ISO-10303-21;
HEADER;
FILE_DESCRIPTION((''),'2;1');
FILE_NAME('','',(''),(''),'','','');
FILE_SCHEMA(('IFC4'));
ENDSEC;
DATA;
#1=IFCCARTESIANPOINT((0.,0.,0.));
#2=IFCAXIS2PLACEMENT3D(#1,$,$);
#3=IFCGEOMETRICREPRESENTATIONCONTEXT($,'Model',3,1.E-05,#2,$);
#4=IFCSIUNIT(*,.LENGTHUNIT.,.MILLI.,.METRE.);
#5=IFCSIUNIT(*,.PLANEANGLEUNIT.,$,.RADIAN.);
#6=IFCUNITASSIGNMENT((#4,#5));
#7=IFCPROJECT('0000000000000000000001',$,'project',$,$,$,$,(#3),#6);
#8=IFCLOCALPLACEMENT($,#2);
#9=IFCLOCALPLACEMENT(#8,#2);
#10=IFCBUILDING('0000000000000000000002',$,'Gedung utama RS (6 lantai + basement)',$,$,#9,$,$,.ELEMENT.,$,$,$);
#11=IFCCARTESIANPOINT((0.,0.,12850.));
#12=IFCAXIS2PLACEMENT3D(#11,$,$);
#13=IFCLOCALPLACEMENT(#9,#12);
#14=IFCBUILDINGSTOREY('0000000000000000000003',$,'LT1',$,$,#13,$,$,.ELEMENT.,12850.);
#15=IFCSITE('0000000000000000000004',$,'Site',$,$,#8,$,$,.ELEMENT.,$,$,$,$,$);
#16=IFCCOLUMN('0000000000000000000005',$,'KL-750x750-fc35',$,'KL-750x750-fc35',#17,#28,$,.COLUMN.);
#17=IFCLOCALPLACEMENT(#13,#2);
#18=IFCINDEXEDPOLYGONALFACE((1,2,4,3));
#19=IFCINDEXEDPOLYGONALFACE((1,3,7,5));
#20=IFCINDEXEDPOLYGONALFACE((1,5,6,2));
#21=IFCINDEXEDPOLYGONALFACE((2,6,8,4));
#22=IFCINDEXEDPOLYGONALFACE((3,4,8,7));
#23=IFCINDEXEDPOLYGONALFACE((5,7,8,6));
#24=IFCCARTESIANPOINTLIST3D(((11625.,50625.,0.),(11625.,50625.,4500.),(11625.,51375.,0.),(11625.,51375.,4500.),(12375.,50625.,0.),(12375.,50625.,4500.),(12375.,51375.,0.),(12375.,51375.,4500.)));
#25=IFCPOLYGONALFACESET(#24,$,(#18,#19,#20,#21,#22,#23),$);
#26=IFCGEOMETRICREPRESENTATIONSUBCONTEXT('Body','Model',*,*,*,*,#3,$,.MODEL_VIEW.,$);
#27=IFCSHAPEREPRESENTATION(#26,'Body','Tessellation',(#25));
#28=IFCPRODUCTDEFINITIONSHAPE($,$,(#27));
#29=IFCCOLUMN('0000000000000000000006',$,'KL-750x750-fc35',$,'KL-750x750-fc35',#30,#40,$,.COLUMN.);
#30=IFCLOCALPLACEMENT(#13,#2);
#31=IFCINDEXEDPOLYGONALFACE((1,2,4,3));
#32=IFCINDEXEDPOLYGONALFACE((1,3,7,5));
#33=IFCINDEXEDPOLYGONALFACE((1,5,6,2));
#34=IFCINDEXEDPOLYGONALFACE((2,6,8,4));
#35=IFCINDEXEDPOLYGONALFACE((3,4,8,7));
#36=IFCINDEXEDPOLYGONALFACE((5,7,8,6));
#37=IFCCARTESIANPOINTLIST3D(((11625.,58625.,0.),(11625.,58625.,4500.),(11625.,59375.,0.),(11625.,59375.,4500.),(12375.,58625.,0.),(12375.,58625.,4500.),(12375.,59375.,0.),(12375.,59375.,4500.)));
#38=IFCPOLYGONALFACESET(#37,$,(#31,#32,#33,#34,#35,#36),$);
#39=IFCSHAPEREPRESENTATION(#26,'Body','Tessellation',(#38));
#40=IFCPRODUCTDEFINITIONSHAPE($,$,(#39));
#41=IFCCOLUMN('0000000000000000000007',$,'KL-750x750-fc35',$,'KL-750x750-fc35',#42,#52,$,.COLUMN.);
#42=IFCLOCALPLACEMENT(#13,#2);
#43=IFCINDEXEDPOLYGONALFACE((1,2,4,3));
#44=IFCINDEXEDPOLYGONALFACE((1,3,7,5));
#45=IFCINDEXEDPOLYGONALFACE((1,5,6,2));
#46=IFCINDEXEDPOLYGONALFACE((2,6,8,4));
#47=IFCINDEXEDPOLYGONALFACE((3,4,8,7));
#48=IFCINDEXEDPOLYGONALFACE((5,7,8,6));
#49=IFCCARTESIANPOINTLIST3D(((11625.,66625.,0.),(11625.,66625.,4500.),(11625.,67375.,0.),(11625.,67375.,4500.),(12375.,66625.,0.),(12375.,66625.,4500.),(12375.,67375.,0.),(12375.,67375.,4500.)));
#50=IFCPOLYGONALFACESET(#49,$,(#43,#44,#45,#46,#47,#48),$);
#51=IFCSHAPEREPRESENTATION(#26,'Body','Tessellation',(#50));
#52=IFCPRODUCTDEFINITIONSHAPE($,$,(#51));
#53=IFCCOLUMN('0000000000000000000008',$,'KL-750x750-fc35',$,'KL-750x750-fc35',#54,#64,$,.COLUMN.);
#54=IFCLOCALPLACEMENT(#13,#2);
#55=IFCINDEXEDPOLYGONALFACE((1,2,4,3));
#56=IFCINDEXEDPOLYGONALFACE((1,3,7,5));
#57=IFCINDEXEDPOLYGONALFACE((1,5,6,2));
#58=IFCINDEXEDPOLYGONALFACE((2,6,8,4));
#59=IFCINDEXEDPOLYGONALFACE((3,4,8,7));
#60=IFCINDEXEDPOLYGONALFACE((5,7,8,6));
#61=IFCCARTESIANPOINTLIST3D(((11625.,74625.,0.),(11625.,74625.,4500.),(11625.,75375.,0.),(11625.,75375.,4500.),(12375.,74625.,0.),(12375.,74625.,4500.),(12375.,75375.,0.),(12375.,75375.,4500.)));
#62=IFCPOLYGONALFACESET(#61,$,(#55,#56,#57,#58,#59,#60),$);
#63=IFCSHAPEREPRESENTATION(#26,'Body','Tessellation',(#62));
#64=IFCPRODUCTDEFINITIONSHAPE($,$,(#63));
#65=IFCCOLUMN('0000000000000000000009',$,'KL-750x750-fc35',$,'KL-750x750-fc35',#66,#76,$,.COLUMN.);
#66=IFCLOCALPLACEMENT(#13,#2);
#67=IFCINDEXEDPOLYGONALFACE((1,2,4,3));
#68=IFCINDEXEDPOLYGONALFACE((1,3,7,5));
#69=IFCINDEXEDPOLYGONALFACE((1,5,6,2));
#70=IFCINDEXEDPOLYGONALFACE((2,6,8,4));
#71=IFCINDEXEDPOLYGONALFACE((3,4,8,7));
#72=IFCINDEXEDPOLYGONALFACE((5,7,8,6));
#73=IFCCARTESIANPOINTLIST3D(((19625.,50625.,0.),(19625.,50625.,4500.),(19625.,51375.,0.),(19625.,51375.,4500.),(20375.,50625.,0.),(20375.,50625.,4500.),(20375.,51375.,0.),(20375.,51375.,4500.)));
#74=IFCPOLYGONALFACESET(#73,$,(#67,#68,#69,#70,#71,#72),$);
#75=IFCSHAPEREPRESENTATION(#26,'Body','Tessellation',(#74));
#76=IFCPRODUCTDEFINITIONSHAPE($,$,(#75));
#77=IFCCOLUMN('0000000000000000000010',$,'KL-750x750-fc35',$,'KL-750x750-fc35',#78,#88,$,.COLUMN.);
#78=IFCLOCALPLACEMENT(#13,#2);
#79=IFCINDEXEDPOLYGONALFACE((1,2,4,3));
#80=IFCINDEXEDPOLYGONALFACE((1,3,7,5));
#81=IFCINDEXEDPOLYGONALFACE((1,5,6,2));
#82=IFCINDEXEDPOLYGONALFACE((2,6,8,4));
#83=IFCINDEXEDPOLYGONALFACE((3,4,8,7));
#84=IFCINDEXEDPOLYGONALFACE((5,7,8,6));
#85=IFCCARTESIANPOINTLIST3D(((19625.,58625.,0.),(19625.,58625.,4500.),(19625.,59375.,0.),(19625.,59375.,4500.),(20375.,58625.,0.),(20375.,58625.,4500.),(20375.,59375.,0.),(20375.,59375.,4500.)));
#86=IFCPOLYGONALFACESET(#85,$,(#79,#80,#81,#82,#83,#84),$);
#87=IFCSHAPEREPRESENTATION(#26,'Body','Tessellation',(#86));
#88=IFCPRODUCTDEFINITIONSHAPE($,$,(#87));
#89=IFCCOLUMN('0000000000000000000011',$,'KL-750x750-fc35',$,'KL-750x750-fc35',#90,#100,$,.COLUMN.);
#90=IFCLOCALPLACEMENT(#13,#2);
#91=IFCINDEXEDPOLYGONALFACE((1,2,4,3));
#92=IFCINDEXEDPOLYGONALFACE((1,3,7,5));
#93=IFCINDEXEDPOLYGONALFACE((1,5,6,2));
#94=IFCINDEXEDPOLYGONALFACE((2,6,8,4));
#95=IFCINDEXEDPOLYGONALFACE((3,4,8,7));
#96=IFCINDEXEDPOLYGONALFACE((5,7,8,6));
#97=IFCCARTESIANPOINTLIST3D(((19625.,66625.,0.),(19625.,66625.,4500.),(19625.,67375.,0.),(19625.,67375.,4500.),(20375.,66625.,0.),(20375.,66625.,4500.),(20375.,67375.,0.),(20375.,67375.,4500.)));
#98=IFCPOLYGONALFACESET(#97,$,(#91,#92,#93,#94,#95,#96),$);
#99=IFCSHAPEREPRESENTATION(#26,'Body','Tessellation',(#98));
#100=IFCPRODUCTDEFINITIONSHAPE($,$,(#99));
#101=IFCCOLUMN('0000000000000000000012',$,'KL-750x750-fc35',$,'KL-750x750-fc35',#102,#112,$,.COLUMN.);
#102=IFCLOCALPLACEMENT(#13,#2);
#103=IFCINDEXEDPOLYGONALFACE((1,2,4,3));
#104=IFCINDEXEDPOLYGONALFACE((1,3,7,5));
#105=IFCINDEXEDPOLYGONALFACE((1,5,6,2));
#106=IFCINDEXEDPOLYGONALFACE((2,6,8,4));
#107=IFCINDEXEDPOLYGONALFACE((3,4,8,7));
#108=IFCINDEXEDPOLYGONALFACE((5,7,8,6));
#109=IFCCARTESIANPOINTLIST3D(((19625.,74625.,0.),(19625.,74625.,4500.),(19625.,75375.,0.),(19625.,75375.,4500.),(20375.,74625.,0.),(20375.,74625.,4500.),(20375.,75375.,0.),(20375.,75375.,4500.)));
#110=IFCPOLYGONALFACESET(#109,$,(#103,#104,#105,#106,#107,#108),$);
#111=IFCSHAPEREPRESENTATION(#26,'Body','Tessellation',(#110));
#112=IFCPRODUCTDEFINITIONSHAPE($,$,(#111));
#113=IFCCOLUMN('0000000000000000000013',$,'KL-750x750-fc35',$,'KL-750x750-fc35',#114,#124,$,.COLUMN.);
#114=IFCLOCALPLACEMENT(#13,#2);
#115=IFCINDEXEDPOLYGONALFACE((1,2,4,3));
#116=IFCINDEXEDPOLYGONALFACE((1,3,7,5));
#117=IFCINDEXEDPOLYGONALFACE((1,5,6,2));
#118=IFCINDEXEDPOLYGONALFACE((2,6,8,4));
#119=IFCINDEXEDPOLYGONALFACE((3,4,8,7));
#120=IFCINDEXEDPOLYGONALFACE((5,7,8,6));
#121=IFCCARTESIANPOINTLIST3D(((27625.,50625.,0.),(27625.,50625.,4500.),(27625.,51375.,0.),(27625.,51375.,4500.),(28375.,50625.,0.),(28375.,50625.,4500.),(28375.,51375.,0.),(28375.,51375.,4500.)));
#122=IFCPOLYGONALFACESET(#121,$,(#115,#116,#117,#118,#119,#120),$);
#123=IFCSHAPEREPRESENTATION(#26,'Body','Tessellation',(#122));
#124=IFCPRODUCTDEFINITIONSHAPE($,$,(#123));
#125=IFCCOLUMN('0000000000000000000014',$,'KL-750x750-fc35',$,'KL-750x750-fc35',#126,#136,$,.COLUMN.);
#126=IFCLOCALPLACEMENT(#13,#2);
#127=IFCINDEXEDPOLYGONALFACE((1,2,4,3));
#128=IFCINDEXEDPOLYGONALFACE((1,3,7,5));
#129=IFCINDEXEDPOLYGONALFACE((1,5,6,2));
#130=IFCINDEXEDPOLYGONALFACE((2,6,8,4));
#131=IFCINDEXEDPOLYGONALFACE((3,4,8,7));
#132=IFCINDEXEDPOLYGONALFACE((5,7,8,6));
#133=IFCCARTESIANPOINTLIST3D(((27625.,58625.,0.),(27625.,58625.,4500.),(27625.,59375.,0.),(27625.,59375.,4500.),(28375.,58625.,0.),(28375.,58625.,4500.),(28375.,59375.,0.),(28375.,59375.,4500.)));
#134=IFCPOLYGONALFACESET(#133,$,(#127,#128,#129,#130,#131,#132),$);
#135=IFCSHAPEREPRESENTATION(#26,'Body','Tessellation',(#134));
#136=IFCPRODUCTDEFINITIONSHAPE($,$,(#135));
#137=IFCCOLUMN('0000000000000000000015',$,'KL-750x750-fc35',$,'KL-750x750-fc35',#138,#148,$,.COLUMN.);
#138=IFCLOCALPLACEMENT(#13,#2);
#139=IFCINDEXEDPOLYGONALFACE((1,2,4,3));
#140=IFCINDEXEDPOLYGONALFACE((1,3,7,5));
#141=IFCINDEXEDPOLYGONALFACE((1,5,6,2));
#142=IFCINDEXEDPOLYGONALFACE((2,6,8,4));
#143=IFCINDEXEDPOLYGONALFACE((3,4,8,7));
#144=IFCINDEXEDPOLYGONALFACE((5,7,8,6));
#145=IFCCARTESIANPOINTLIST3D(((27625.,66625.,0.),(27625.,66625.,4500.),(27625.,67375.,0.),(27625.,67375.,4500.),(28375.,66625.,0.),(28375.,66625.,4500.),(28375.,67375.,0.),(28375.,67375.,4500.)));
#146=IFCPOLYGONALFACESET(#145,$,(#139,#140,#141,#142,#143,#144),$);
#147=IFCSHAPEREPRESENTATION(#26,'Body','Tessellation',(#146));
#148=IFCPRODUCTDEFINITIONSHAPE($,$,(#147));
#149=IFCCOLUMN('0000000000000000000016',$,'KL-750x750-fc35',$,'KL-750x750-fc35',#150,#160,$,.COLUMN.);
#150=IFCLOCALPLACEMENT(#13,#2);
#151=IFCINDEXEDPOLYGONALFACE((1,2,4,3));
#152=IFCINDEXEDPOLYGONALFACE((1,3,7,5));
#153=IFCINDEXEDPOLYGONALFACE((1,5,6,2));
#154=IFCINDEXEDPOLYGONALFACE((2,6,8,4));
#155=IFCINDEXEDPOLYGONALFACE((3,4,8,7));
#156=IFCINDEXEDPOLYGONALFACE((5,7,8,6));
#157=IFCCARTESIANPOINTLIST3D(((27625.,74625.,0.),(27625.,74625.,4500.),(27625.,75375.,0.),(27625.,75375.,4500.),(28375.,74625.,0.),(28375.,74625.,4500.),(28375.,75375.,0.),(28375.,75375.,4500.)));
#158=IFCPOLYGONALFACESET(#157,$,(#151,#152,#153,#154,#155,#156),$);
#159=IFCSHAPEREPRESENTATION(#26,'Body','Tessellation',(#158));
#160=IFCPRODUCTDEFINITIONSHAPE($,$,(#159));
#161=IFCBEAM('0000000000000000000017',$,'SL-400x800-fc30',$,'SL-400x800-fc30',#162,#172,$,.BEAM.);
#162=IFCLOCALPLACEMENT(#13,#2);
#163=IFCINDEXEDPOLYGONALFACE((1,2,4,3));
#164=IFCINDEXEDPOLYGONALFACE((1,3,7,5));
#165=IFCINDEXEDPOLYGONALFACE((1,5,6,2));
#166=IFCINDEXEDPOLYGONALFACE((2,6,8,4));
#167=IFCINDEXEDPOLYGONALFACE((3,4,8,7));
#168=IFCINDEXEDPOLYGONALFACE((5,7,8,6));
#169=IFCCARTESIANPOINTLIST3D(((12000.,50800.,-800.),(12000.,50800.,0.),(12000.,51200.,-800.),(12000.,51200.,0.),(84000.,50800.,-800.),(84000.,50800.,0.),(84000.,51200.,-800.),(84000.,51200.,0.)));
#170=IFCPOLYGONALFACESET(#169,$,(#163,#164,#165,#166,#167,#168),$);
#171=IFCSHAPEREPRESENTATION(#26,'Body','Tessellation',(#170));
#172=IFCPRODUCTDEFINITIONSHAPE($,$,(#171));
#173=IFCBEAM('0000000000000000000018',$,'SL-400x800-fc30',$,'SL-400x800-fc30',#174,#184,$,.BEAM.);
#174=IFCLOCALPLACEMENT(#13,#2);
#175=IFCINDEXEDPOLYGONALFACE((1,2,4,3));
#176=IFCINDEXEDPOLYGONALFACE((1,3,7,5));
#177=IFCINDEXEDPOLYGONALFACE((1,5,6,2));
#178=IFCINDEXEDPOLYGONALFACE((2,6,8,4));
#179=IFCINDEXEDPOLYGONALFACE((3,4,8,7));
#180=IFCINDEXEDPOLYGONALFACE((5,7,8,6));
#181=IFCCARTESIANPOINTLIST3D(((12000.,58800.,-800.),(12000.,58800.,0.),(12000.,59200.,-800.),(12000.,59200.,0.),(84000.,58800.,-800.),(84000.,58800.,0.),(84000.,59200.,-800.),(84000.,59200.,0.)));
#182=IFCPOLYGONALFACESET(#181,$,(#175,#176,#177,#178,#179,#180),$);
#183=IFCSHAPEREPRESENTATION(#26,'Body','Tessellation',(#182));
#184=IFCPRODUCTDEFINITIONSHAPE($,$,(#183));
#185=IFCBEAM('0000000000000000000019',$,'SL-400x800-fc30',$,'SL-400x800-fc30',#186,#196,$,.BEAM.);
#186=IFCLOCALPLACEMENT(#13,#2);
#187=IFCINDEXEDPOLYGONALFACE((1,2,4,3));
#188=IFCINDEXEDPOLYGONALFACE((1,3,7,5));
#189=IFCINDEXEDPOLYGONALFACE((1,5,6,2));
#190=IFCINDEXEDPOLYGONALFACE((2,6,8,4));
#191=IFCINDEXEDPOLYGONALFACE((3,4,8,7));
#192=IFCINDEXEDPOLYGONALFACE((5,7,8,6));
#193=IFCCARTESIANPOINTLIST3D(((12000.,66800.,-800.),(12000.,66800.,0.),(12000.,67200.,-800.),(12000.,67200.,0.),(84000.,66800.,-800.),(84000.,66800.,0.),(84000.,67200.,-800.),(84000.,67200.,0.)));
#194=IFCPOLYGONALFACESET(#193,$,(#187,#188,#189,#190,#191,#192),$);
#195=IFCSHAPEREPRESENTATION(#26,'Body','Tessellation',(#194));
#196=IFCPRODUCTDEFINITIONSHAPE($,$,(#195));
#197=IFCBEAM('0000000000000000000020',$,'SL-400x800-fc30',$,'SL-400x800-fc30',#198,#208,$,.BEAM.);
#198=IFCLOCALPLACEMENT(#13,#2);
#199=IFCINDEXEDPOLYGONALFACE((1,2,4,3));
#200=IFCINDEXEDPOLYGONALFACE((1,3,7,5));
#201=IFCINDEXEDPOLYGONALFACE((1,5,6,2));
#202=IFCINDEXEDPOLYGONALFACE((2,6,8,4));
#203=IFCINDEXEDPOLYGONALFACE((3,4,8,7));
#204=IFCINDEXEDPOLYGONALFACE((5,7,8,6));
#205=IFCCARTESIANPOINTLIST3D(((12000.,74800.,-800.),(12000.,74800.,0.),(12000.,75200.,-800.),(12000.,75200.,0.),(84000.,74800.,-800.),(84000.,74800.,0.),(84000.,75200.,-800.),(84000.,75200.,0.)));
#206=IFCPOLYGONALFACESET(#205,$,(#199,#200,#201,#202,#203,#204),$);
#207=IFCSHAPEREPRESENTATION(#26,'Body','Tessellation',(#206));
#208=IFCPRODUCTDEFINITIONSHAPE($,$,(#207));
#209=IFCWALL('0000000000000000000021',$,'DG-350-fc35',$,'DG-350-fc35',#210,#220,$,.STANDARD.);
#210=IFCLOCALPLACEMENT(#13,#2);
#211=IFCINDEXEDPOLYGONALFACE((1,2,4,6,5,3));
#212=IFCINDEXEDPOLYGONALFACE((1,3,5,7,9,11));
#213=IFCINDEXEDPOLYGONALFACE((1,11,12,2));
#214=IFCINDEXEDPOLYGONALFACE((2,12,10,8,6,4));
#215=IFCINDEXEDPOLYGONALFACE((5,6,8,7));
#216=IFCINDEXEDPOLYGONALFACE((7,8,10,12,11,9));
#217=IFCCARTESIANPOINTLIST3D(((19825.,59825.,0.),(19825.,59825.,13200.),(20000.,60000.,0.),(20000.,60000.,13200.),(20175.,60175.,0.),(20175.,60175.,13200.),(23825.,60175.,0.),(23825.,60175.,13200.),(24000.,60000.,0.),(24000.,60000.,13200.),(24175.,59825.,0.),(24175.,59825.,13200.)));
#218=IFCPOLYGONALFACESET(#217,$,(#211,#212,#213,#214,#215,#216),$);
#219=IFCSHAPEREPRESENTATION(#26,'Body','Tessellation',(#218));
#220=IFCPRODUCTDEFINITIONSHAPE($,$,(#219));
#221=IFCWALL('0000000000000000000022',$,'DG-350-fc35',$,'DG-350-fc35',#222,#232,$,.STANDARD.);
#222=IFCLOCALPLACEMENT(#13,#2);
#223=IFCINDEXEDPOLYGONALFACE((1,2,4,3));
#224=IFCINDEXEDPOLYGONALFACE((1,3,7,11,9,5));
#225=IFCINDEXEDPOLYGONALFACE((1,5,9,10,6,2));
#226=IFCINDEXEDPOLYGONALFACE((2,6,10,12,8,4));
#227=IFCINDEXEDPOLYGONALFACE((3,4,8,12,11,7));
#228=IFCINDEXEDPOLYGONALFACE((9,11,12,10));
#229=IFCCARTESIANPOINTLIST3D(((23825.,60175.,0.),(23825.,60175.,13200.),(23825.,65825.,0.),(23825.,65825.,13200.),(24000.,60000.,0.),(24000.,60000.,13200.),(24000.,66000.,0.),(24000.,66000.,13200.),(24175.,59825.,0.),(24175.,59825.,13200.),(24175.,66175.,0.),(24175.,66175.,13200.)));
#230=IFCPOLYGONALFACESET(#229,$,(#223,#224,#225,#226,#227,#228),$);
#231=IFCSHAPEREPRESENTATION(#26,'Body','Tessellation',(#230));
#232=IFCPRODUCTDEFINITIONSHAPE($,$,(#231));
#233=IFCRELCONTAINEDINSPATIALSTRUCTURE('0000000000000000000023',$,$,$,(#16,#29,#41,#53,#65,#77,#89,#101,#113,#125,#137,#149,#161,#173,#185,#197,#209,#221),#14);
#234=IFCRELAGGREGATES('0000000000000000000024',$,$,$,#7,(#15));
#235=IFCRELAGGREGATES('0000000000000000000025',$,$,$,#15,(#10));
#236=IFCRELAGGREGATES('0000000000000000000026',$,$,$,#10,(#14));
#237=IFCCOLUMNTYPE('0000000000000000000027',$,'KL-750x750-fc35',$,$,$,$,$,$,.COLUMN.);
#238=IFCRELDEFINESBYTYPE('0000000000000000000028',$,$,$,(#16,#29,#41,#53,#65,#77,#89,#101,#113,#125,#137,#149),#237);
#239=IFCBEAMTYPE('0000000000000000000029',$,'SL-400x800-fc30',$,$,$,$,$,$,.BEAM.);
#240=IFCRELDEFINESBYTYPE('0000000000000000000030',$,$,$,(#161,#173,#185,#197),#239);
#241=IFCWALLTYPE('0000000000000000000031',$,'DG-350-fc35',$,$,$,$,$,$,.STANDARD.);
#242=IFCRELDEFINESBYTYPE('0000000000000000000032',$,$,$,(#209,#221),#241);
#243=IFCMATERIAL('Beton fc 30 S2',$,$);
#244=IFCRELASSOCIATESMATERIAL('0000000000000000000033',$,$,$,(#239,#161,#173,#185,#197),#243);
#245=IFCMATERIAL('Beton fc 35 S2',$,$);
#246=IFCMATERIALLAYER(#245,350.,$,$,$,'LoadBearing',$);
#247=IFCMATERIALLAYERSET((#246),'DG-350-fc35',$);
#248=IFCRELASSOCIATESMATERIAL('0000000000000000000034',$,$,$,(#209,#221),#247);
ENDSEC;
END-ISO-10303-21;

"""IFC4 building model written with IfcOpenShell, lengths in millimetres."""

from ifc_helpers import new_model, si_unit, frame, origin, origin_2d, place, context, subcontext, project, spatial, polyline, rectangle, outline, extrude, material, layer, layer_set, layer_usage, material_profile, profile_set, profile_usage, type_object, element, save


model = new_model("IFC4")

# Units and contexts
model_context = context("Model", 3, precision=1e-05, world=origin())
body_context = subcontext(model_context, "Body", "Model", "MODEL_VIEW")
ifc_project = project(units=[si_unit("LENGTHUNIT", "METRE", prefix="MILLI"), si_unit("PLANEANGLEUNIT", "RADIAN")], contexts=[model_context])

# Site, building, storey
site_placement = place(None, origin())
site = spatial("IfcSite", under=ifc_project, at=site_placement, Name="Site", CompositionType="ELEMENT")
building_placement = place(site_placement, origin())
building = spatial("IfcBuilding", under=site, at=building_placement, Name="Gedung utama RS (6 lantai + basement)", CompositionType="ELEMENT")
storey_placement = place(building_placement, frame((0.0, 0.0, 12850.0)))
storey = spatial("IfcBuildingStorey", under=building, at=storey_placement, Name="LT1", CompositionType="ELEMENT", Elevation=12850.0)

# Columns
ifc_material_profile_1 = material_profile(None, rectangle(XDim=750.0, YDim=750.0, at=origin_2d()), Name="KL-750x750-fc35")
ifc_profile_set_1 = profile_set([ifc_material_profile_1], Name="KL-750x750-fc35")
ifc_profile_usage_1 = profile_usage(ifc_profile_set_1, cardinal=5)
column_type = type_object("IfcColumnType", Name="KL-750x750-fc35", PredefinedType="COLUMN", material=ifc_profile_set_1)
for number, where, z_axis, x_axis, name in (
    (1, (12000.0, 51000.0, 0.0), (0.0, 0.0, 1.0), (1.0, 0.0, 0.0), "KL-750x750-fc35"),
    (2, (12000.0, 59000.0, 0.0), (0.0, 0.0, 1.0), (1.0, 0.0, 0.0), "KL-750x750-fc35"),
    (3, (12000.0, 67000.0, 0.0), (0.0, 0.0, 1.0), (1.0, 0.0, 0.0), "KL-750x750-fc35"),
    (4, (12000.0, 75000.0, 0.0), (0.0, 0.0, 1.0), (1.0, 0.0, 0.0), "KL-750x750-fc35"),
    (5, (20000.0, 51000.0, 0.0), (0.0, 0.0, 1.0), (1.0, 0.0, 0.0), "KL-750x750-fc35"),
    (6, (20000.0, 59000.0, 0.0), (0.0, 0.0, 1.0), (1.0, 0.0, 0.0), "KL-750x750-fc35"),
    (7, (20000.0, 67000.0, 0.0), (0.0, 0.0, 1.0), (1.0, 0.0, 0.0), "KL-750x750-fc35"),
    (8, (20000.0, 75000.0, 0.0), (0.0, 0.0, 1.0), (1.0, 0.0, 0.0), "KL-750x750-fc35"),
    (9, (28000.0, 51000.0, 0.0), (0.0, 0.0, 1.0), (1.0, 0.0, 0.0), "KL-750x750-fc35"),
    (10, (28000.0, 59000.0, 0.0), (0.0, 0.0, 1.0), (1.0, 0.0, 0.0), "KL-750x750-fc35"),
    (11, (28000.0, 67000.0, 0.0), (0.0, 0.0, 1.0), (1.0, 0.0, 0.0), "KL-750x750-fc35"),
    (12, (28000.0, 75000.0, 0.0), (0.0, 0.0, 1.0), (1.0, 0.0, 0.0), "KL-750x750-fc35"),
):
    element("IfcColumn", number, at=place(storey_placement, frame(where, z_axis=z_axis, x_axis=x_axis)), inside=storey, type_object=column_type, material=ifc_profile_usage_1, Name=name, ObjectType="KL-750x750-fc35", PredefinedType="COLUMN", context=body_context, shape_type="SweptSolid", body=[
        extrude(rectangle(XDim=750.0, YDim=750.0, at=origin_2d()), origin(), (0.0, 0.0, 1.0), 4500.0),
    ])

# Beams
ifc_material_1 = material(Name="Beton fc 30 S2")
ifc_material_profile_2 = material_profile(ifc_material_1, rectangle(XDim=400.0, YDim=800.0, at=origin_2d()), Name="SL-400x800-fc30")
ifc_profile_set_2 = profile_set([ifc_material_profile_2], Name="SL-400x800-fc30")
ifc_profile_usage_2 = profile_usage(ifc_profile_set_2, cardinal=8)
beam_type = type_object("IfcBeamType", Name="SL-400x800-fc30", PredefinedType="BEAM", material=ifc_profile_set_2)
for number, where, name in (
    (13, (12000.0, 51000.0, -400.0), "SL-400x800-fc30"),
    (14, (12000.0, 59000.0, -400.0), "SL-400x800-fc30"),
    (15, (12000.0, 67000.0, -400.0), "SL-400x800-fc30"),
    (16, (12000.0, 75000.0, -400.0), "SL-400x800-fc30"),
):
    element("IfcBeam", number, at=place(storey_placement, frame(where)), inside=storey, type_object=beam_type, material=ifc_profile_usage_2, Name=name, ObjectType="SL-400x800-fc30", PredefinedType="BEAM", context=body_context, shape_type="SweptSolid", body=[
        extrude(rectangle(XDim=400.0, YDim=800.0, at=origin_2d()), frame((0.0, 0.0, 0.0), z_axis=(1.0, 0.0, 0.0), x_axis=(0.0, 1.0, 0.0)), (0.0, 0.0, 1.0), 72000.0),
    ])

# Walls
ifc_material_2 = material(Name="Beton fc 35 S2")
ifc_layer = layer(ifc_material_2, 350.0, Category="LoadBearing")
ifc_layer_set = layer_set([ifc_layer], Name="DG-350-fc35")
ifc_layer_usage = layer_usage(ifc_layer_set, "AXIS2", "NEGATIVE", 175.0)
wall_type = type_object("IfcWallType", Name="DG-350-fc35", PredefinedType="STANDARD")
wall_1_placement = place(storey_placement, frame((20000.0, 60000.0, 0.0), z_axis=(0.0, 0.0, 1.0), x_axis=(1.0, 0.0, 0.0)))
element("IfcWall", 17, at=wall_1_placement, inside=storey, type_object=wall_type, material=ifc_layer_usage, Name="DG-350-fc35", ObjectType="DG-350-fc35", PredefinedType="STANDARD", context=body_context, shape_type="SweptSolid", body=[
    extrude(outline(polyline([(-175.0, -175.0), (0.0, 0.0), (175.0, 175.0), (3825.0, 175.0), (4000.0, 0.0), (4175.0, -175.0), (-175.0, -175.0)])), origin(), (0.0, 0.0, 1.0), 13200.0),
])
wall_2_placement = place(storey_placement, frame((24000.0, 60000.0, 0.0), z_axis=(0.0, 0.0, 1.0), x_axis=(0.0, 1.0, 0.0)))
element("IfcWall", 18, at=wall_2_placement, inside=storey, type_object=wall_type, material=ifc_layer_usage, Name="DG-350-fc35", ObjectType="DG-350-fc35", PredefinedType="STANDARD", context=body_context, shape_type="SweptSolid", body=[
    extrude(outline(polyline([(-175.0, -175.0), (0.0, 0.0), (175.0, 175.0), (5825.0, 175.0), (6000.0, 0.0), (6175.0, -175.0), (-175.0, -175.0)])), origin(), (0.0, 0.0, 1.0), 13200.0),
])

save(model, "model.ifc")
